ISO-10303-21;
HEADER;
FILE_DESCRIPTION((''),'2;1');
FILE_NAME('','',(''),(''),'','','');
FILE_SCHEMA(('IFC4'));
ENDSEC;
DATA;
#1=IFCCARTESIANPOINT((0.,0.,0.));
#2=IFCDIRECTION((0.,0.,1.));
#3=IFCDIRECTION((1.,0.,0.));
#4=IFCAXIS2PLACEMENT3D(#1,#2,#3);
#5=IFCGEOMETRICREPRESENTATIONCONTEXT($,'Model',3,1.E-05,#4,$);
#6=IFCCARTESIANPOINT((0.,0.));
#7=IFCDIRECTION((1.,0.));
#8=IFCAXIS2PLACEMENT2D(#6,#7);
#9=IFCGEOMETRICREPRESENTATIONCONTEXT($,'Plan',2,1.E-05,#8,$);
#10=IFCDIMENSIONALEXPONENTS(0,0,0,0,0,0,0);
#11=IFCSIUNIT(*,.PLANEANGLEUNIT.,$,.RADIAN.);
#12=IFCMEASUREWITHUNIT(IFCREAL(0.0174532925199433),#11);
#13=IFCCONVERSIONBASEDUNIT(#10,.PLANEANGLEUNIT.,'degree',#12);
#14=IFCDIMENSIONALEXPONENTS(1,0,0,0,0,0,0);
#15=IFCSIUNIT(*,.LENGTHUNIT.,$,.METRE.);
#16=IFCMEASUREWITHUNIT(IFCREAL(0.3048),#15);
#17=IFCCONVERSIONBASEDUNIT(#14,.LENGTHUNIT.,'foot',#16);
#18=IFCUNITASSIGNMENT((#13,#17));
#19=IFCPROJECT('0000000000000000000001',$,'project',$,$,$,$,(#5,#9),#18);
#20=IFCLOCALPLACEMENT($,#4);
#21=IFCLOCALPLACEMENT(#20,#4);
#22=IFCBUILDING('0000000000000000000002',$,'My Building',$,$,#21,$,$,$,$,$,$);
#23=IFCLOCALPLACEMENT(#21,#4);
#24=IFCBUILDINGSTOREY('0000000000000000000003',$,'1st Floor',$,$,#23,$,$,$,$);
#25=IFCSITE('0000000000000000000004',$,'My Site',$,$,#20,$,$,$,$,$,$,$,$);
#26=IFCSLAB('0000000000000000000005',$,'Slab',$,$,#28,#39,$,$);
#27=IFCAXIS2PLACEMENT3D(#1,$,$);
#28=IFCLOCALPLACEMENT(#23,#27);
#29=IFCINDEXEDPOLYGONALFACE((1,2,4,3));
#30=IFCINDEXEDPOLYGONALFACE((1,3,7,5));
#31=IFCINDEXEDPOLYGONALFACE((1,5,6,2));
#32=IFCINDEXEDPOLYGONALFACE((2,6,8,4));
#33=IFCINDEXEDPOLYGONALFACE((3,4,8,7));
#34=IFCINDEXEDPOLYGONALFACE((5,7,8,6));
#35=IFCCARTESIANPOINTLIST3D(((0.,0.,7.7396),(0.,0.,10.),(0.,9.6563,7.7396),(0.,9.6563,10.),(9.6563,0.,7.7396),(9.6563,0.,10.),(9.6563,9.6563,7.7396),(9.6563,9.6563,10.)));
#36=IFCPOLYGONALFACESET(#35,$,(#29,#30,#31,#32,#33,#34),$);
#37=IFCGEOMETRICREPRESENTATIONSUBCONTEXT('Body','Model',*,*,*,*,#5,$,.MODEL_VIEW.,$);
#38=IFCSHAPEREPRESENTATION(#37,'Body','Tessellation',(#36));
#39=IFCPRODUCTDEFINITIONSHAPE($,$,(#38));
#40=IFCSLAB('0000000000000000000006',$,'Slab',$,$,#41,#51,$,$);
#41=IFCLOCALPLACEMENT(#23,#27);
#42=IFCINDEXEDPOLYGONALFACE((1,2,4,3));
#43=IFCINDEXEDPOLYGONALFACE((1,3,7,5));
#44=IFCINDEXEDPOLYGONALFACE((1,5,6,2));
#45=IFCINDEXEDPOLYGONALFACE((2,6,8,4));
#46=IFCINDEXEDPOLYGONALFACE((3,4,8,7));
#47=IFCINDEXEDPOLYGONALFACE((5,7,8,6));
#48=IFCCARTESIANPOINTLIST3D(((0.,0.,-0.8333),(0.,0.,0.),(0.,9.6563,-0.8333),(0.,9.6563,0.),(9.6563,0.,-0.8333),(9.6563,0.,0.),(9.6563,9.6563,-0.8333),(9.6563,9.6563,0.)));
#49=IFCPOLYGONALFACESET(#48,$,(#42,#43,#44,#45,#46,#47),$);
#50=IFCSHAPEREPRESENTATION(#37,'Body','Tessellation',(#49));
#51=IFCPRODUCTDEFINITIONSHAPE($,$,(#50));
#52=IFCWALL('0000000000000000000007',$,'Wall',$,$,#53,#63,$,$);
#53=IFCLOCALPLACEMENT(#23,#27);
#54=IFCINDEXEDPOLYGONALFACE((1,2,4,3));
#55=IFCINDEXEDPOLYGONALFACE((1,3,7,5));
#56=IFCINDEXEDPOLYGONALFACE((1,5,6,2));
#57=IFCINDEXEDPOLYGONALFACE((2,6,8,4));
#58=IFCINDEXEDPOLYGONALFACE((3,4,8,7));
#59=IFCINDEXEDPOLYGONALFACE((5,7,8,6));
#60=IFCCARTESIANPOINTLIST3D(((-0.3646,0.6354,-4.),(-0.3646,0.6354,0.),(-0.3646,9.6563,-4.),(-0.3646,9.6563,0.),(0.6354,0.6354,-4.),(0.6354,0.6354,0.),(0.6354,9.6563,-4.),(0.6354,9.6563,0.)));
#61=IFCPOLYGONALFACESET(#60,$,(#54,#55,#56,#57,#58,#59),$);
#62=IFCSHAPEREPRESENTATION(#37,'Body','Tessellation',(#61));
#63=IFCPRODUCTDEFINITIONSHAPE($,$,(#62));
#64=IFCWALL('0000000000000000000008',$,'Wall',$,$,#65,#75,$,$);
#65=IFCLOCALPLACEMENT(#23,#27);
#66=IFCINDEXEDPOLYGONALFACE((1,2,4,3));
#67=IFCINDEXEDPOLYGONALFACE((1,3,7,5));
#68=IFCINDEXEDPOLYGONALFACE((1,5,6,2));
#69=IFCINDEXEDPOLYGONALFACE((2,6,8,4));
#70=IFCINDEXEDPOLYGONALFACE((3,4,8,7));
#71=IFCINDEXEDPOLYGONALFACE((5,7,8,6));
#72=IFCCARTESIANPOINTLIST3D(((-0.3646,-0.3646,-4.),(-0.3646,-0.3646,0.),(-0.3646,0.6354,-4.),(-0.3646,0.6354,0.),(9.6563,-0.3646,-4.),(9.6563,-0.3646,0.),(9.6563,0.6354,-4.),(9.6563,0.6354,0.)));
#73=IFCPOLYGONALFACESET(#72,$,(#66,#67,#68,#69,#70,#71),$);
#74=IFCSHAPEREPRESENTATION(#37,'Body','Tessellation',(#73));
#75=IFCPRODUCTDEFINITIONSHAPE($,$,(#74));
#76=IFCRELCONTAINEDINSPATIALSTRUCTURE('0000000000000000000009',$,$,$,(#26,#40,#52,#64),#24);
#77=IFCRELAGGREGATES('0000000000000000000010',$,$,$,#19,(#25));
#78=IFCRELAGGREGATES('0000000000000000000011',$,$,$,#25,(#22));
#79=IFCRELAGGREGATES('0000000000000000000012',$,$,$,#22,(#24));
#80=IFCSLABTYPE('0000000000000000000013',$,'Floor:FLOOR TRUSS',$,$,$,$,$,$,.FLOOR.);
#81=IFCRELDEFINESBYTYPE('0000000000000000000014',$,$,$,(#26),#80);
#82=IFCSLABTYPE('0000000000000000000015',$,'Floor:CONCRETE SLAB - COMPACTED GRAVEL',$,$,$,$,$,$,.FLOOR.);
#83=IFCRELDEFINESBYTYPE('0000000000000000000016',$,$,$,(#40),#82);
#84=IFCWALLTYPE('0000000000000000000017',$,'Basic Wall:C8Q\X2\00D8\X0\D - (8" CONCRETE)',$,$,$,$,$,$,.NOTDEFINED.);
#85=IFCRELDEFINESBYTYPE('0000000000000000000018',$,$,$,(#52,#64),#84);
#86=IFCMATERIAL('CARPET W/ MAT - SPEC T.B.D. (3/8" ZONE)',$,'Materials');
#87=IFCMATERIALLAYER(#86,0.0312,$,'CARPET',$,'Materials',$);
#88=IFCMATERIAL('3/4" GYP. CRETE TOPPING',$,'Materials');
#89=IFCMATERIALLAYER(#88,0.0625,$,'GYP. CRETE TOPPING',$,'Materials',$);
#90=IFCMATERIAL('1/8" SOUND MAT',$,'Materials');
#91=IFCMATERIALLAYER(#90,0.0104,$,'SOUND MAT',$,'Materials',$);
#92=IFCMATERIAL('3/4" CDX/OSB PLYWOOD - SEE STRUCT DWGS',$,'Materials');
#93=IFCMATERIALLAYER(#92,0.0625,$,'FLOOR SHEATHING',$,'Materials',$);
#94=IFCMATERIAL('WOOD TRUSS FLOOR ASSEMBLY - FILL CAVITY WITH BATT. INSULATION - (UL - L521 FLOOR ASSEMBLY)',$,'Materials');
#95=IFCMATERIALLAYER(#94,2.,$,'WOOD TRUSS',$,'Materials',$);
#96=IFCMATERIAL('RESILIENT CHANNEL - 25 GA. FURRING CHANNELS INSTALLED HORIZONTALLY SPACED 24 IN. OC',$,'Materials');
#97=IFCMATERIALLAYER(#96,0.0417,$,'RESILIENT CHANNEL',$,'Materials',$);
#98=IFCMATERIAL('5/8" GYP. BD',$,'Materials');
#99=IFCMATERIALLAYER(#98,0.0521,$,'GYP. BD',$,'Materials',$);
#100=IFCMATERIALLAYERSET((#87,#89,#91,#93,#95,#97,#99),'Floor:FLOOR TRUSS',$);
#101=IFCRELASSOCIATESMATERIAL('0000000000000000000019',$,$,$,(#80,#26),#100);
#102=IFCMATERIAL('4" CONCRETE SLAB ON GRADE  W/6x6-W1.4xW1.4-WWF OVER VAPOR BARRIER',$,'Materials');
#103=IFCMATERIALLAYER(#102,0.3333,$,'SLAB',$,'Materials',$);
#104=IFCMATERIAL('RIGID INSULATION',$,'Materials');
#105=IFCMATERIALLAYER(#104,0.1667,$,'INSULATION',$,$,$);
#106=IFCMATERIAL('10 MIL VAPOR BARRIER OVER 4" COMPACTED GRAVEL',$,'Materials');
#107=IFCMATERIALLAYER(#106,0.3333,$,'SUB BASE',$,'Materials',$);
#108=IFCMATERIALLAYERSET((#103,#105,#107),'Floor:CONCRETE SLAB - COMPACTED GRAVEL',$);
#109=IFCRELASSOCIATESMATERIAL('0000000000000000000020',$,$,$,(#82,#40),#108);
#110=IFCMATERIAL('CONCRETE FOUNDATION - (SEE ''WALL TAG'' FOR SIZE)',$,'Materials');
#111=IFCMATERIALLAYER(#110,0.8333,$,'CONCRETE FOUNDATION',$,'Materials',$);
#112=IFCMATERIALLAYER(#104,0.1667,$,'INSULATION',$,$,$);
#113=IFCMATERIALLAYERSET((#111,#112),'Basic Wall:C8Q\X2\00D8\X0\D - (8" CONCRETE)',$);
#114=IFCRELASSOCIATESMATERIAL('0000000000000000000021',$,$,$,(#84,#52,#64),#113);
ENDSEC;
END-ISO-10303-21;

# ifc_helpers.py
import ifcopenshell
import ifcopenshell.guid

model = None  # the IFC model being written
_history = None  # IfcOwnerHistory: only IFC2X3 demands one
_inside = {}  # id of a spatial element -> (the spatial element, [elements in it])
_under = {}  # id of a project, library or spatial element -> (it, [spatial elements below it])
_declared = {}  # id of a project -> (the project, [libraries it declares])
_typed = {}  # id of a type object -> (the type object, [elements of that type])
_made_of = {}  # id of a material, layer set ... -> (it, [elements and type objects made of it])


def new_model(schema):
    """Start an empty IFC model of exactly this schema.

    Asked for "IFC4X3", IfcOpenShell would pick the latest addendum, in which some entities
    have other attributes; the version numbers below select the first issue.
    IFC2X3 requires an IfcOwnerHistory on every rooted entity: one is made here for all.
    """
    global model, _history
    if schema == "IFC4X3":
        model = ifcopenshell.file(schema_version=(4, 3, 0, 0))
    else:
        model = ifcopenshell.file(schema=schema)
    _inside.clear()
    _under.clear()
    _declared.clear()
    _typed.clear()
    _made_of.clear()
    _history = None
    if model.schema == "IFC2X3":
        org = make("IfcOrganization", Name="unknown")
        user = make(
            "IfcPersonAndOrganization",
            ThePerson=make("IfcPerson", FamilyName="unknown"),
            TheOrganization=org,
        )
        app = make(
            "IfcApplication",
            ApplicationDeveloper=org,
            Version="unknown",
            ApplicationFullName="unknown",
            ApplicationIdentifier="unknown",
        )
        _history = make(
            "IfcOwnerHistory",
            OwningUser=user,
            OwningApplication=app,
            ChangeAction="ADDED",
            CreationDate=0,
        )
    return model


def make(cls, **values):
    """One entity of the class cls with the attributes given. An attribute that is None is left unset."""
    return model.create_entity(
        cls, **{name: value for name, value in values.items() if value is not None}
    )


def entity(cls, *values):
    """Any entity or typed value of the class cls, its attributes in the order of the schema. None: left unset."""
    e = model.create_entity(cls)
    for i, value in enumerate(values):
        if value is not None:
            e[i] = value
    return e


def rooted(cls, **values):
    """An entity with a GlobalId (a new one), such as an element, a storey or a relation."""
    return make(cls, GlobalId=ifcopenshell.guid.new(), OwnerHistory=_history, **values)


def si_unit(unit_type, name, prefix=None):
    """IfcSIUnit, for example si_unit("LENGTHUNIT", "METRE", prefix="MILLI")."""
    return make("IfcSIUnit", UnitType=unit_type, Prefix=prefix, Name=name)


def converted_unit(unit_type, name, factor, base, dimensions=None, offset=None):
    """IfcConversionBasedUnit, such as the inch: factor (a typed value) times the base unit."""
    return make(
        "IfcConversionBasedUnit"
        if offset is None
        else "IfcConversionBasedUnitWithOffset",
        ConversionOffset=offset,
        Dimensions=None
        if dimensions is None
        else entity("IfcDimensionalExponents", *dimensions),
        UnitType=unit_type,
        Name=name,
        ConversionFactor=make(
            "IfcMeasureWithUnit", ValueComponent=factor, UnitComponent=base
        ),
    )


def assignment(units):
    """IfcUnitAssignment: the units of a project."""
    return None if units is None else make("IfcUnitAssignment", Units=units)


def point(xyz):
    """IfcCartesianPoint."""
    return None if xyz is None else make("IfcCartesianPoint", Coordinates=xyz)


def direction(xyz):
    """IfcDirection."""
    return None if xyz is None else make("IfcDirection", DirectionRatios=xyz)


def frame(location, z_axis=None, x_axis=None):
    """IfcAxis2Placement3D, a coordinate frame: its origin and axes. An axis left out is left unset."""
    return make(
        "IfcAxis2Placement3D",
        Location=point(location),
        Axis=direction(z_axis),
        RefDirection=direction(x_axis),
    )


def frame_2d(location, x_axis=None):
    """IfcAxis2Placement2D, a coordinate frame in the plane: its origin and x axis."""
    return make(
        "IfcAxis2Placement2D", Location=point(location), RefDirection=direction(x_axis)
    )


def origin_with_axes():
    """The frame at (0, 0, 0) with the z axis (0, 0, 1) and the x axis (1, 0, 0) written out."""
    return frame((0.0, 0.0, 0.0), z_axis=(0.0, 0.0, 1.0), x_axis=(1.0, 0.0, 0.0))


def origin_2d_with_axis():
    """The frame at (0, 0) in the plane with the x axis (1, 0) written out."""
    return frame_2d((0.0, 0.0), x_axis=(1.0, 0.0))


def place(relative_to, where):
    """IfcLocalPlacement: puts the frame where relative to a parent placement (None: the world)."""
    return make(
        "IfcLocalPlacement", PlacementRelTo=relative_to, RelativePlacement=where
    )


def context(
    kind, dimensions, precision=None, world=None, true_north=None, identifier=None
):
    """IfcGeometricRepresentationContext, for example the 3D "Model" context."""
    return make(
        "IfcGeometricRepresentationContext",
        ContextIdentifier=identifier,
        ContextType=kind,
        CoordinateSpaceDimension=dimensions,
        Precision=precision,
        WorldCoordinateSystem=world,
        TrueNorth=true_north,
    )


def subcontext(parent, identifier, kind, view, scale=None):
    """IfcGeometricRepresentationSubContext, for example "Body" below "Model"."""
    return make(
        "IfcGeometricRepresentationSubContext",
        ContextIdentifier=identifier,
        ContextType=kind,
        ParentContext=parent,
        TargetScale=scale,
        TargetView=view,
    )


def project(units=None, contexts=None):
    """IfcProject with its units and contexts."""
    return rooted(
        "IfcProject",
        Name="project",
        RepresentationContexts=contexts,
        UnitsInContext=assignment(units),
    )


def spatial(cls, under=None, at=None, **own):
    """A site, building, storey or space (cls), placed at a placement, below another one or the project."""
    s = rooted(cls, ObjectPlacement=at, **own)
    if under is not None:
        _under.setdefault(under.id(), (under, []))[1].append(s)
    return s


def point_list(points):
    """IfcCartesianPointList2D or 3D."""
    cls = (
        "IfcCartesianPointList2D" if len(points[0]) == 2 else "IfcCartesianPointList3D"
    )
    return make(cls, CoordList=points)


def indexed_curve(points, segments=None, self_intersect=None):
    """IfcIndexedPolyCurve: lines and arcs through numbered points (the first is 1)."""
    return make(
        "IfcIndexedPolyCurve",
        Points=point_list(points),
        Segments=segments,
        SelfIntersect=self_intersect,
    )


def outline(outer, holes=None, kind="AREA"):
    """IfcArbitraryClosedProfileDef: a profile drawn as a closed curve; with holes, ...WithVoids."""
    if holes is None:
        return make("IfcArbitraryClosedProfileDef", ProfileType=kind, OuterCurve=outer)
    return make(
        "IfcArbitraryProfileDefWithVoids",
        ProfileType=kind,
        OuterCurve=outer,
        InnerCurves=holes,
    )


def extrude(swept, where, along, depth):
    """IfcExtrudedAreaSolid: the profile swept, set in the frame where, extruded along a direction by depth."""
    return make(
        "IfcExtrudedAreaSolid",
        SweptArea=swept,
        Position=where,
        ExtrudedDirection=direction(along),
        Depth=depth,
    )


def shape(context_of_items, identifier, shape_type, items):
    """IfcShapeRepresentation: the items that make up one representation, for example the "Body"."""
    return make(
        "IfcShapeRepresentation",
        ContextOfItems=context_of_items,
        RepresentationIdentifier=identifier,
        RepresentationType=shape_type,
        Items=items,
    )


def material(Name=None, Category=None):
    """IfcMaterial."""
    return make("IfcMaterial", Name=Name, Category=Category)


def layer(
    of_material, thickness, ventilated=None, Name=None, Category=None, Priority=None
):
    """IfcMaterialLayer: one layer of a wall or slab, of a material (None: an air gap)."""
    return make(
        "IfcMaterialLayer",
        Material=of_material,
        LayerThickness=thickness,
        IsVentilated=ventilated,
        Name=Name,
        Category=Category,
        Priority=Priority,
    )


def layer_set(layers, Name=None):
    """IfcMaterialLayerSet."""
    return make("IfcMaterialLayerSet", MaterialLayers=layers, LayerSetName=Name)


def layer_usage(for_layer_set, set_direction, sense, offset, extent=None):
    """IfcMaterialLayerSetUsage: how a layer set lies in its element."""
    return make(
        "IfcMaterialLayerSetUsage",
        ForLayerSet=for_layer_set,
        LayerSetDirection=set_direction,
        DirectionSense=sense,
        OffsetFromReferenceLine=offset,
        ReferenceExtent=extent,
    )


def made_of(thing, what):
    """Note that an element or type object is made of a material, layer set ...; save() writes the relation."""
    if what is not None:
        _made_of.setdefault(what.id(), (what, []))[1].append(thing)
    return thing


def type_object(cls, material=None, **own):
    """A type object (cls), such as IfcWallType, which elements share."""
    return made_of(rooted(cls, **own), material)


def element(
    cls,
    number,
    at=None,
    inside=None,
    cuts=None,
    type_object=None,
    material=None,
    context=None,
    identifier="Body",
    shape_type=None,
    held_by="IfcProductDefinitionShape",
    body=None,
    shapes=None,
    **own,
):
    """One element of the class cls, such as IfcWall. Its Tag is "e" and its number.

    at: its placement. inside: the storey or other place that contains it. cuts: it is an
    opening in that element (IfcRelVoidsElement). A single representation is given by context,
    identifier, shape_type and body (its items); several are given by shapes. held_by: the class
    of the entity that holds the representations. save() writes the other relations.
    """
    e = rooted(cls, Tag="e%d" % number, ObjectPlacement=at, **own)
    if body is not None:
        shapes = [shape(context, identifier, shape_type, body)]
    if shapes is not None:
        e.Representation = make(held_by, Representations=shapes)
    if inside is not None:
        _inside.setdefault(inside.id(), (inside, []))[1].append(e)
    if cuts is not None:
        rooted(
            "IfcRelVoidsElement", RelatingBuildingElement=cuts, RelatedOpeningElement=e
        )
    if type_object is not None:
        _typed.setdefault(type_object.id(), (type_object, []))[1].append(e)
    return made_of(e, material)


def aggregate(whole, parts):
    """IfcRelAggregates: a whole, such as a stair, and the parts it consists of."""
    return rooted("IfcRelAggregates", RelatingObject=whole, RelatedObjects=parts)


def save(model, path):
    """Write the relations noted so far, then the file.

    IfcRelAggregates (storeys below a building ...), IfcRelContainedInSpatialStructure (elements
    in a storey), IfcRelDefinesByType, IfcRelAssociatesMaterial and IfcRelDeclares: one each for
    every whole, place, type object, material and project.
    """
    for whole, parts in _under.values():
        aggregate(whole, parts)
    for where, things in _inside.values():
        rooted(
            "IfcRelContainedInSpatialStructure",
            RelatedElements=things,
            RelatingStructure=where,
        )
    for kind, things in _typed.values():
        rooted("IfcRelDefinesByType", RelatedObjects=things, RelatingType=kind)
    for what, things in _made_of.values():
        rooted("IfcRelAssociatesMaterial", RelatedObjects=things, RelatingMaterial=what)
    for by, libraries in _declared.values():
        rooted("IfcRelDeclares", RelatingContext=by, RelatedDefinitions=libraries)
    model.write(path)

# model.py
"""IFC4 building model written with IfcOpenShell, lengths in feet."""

from ifc_helpers import new_model, entity, si_unit, converted_unit, frame, origin_with_axes, origin_2d_with_axis, place, context, subcontext, project, spatial, indexed_curve, outline, extrude, material, layer, layer_set, layer_usage, type_object, element, save


model = new_model("IFC4")

# Units and contexts
model_context = context("Model", 3, precision=1e-05, world=origin_with_axes())
plan_context = context("Plan", 2, precision=1e-05, world=origin_2d_with_axis())
body_context = subcontext(model_context, "Body", "Model", "MODEL_VIEW")
ifc_project = project(units=[converted_unit("PLANEANGLEUNIT", "degree", entity("IfcReal", 0.0174532925199433), si_unit("PLANEANGLEUNIT", "RADIAN"), dimensions=[0, 0, 0, 0, 0, 0, 0]), converted_unit("LENGTHUNIT", "foot", entity("IfcReal", 0.3048), si_unit("LENGTHUNIT", "METRE"), dimensions=[1, 0, 0, 0, 0, 0, 0])], contexts=[model_context, plan_context])

# Site, building, storey
site_placement = place(None, origin_with_axes())
site = spatial("IfcSite", under=ifc_project, at=site_placement, Name="My Site")
building_placement = place(site_placement, origin_with_axes())
building = spatial("IfcBuilding", under=site, at=building_placement, Name="My Building")
storey_placement = place(building_placement, origin_with_axes())
storey = spatial("IfcBuildingStorey", under=building, at=storey_placement, Name="1st Floor")

# Slabs
ifc_material_1 = material(Name="CARPET W/ MAT - SPEC T.B.D. (3/8\" ZONE)", Category="Materials")
ifc_layer_1 = layer(ifc_material_1, 0.0312, Name="CARPET", Category="Materials")
ifc_material_2 = material(Name="3/4\" GYP. CRETE TOPPING", Category="Materials")
ifc_layer_2 = layer(ifc_material_2, 0.0625, Name="GYP. CRETE TOPPING", Category="Materials")
ifc_material_3 = material(Name="1/8\" SOUND MAT", Category="Materials")
ifc_layer_3 = layer(ifc_material_3, 0.0104, Name="SOUND MAT", Category="Materials")
ifc_material_4 = material(Name="3/4\" CDX/OSB PLYWOOD - SEE STRUCT DWGS", Category="Materials")
ifc_layer_4 = layer(ifc_material_4, 0.0625, Name="FLOOR SHEATHING", Category="Materials")
ifc_material_5 = material(Name="WOOD TRUSS FLOOR ASSEMBLY - FILL CAVITY WITH BATT. INSULATION - (UL - L521 FLOOR ASSEMBLY)", Category="Materials")
ifc_layer_5 = layer(ifc_material_5, 2.0, Name="WOOD TRUSS", Category="Materials")
ifc_material_6 = material(Name="RESILIENT CHANNEL - 25 GA. FURRING CHANNELS INSTALLED HORIZONTALLY SPACED 24 IN. OC", Category="Materials")
ifc_layer_6 = layer(ifc_material_6, 0.0417, Name="RESILIENT CHANNEL", Category="Materials")
ifc_material_7 = material(Name="5/8\" GYP. BD", Category="Materials")
ifc_layer_7 = layer(ifc_material_7, 0.0521, Name="GYP. BD", Category="Materials")
ifc_layer_set_1 = layer_set([ifc_layer_1, ifc_layer_2, ifc_layer_3, ifc_layer_4, ifc_layer_5, ifc_layer_6, ifc_layer_7], Name="Floor:FLOOR TRUSS")
ifc_layer_usage_1 = layer_usage(ifc_layer_set_1, "AXIS3", "POSITIVE", 0.0)
slab_type_1 = type_object("IfcSlabType", Name="Floor:FLOOR TRUSS", PredefinedType="FLOOR", material=ifc_layer_set_1)
slab_1_placement = place(storey_placement, frame((0.0, 0.0, 7.7396), z_axis=(0.0, 0.0, 1.0), x_axis=(1.0, 0.0, 0.0)))
element("IfcSlab", 1, at=slab_1_placement, inside=storey, type_object=slab_type_1, material=ifc_layer_usage_1, Name="Slab", context=body_context, shape_type="SweptSolid", body=[
    extrude(outline(indexed_curve([(9.6563, 9.6563), (0.0, 9.6563), (0.0, 0.0), (9.6563, 0.0), (9.6563, 9.6563)])), None, (0.0, 0.0, 1.0), 2.2604),
])
ifc_material_8 = material(Name="4\" CONCRETE SLAB ON GRADE  W/6x6-W1.4xW1.4-WWF OVER VAPOR BARRIER", Category="Materials")
ifc_layer_8 = layer(ifc_material_8, 0.3333, Name="SLAB", Category="Materials")
ifc_material_9 = material(Name="RIGID INSULATION", Category="Materials")
ifc_layer_9 = layer(ifc_material_9, 0.1667, Name="INSULATION")
ifc_material_10 = material(Name="10 MIL VAPOR BARRIER OVER 4\" COMPACTED GRAVEL", Category="Materials")
ifc_layer_10 = layer(ifc_material_10, 0.3333, Name="SUB BASE", Category="Materials")
ifc_layer_set_2 = layer_set([ifc_layer_8, ifc_layer_9, ifc_layer_10], Name="Floor:CONCRETE SLAB - COMPACTED GRAVEL")
ifc_layer_usage_2 = layer_usage(ifc_layer_set_2, "AXIS3", "POSITIVE", 0.0)
slab_type_2 = type_object("IfcSlabType", Name="Floor:CONCRETE SLAB - COMPACTED GRAVEL", PredefinedType="FLOOR", material=ifc_layer_set_2)
slab_2_placement = place(storey_placement, frame((0.0, 0.0, -0.8333), z_axis=(0.0, 0.0, 1.0), x_axis=(1.0, 0.0, 0.0)))
element("IfcSlab", 2, at=slab_2_placement, inside=storey, type_object=slab_type_2, material=ifc_layer_usage_2, Name="Slab", context=body_context, shape_type="SweptSolid", body=[
    extrude(outline(indexed_curve([(9.6563, 9.6563), (9.6563, 0.0), (0.0, 0.0), (0.0, 9.6563), (9.6563, 9.6563)])), None, (0.0, 0.0, 1.0), 0.8333),
])

# Walls
ifc_material_11 = material(Name="CONCRETE FOUNDATION - (SEE 'WALL TAG' FOR SIZE)", Category="Materials")
ifc_layer_11 = layer(ifc_material_11, 0.8333, Name="CONCRETE FOUNDATION", Category="Materials")
ifc_layer_12 = layer(ifc_material_9, 0.1667, Name="INSULATION")
ifc_layer_set_3 = layer_set([ifc_layer_11, ifc_layer_12], Name="Basic Wall:C8QØD - (8\" CONCRETE)")
ifc_layer_usage_3 = layer_usage(ifc_layer_set_3, "AXIS2", "POSITIVE", 0.0)
wall_type = type_object("IfcWallType", Name="Basic Wall:C8QØD - (8\" CONCRETE)", PredefinedType="NOTDEFINED", material=ifc_layer_set_3)
wall_1_placement = place(storey_placement, frame((-0.3646, 9.6563, -4.0), z_axis=(0.0, 0.0, 1.0), x_axis=(0.0, -1.0, 0.0)))
element("IfcWall", 3, at=wall_1_placement, inside=storey, type_object=wall_type, material=ifc_layer_usage_3, Name="Wall", context=body_context, shape_type="SweptSolid", body=[
    extrude(outline(indexed_curve([(0.0, 0.0), (0.0, 1.0), (9.0208, 1.0), (9.0208, 0.0), (0.0, 0.0)], self_intersect=False)), origin_with_axes(), (0.0, 0.0, 1.0), 4.0),
])
ifc_layer_usage_4 = layer_usage(ifc_layer_set_3, "AXIS2", "POSITIVE", 0.0)
wall_2_placement = place(storey_placement, frame((-0.3646, -0.3646, -4.0), z_axis=(0.0, 0.0, 1.0), x_axis=(1.0, 0.0, 0.0)))
element("IfcWall", 4, at=wall_2_placement, inside=storey, type_object=wall_type, material=ifc_layer_usage_4, Name="Wall", context=body_context, shape_type="SweptSolid", body=[
    extrude(outline(indexed_curve([(0.0, 0.0), (0.0, 1.0), (10.0208, 1.0), (10.0208, 0.0), (0.0, 0.0)], self_intersect=False)), origin_with_axes(), (0.0, 0.0, 1.0), 4.0),
])

save(model, "model.ifc")
